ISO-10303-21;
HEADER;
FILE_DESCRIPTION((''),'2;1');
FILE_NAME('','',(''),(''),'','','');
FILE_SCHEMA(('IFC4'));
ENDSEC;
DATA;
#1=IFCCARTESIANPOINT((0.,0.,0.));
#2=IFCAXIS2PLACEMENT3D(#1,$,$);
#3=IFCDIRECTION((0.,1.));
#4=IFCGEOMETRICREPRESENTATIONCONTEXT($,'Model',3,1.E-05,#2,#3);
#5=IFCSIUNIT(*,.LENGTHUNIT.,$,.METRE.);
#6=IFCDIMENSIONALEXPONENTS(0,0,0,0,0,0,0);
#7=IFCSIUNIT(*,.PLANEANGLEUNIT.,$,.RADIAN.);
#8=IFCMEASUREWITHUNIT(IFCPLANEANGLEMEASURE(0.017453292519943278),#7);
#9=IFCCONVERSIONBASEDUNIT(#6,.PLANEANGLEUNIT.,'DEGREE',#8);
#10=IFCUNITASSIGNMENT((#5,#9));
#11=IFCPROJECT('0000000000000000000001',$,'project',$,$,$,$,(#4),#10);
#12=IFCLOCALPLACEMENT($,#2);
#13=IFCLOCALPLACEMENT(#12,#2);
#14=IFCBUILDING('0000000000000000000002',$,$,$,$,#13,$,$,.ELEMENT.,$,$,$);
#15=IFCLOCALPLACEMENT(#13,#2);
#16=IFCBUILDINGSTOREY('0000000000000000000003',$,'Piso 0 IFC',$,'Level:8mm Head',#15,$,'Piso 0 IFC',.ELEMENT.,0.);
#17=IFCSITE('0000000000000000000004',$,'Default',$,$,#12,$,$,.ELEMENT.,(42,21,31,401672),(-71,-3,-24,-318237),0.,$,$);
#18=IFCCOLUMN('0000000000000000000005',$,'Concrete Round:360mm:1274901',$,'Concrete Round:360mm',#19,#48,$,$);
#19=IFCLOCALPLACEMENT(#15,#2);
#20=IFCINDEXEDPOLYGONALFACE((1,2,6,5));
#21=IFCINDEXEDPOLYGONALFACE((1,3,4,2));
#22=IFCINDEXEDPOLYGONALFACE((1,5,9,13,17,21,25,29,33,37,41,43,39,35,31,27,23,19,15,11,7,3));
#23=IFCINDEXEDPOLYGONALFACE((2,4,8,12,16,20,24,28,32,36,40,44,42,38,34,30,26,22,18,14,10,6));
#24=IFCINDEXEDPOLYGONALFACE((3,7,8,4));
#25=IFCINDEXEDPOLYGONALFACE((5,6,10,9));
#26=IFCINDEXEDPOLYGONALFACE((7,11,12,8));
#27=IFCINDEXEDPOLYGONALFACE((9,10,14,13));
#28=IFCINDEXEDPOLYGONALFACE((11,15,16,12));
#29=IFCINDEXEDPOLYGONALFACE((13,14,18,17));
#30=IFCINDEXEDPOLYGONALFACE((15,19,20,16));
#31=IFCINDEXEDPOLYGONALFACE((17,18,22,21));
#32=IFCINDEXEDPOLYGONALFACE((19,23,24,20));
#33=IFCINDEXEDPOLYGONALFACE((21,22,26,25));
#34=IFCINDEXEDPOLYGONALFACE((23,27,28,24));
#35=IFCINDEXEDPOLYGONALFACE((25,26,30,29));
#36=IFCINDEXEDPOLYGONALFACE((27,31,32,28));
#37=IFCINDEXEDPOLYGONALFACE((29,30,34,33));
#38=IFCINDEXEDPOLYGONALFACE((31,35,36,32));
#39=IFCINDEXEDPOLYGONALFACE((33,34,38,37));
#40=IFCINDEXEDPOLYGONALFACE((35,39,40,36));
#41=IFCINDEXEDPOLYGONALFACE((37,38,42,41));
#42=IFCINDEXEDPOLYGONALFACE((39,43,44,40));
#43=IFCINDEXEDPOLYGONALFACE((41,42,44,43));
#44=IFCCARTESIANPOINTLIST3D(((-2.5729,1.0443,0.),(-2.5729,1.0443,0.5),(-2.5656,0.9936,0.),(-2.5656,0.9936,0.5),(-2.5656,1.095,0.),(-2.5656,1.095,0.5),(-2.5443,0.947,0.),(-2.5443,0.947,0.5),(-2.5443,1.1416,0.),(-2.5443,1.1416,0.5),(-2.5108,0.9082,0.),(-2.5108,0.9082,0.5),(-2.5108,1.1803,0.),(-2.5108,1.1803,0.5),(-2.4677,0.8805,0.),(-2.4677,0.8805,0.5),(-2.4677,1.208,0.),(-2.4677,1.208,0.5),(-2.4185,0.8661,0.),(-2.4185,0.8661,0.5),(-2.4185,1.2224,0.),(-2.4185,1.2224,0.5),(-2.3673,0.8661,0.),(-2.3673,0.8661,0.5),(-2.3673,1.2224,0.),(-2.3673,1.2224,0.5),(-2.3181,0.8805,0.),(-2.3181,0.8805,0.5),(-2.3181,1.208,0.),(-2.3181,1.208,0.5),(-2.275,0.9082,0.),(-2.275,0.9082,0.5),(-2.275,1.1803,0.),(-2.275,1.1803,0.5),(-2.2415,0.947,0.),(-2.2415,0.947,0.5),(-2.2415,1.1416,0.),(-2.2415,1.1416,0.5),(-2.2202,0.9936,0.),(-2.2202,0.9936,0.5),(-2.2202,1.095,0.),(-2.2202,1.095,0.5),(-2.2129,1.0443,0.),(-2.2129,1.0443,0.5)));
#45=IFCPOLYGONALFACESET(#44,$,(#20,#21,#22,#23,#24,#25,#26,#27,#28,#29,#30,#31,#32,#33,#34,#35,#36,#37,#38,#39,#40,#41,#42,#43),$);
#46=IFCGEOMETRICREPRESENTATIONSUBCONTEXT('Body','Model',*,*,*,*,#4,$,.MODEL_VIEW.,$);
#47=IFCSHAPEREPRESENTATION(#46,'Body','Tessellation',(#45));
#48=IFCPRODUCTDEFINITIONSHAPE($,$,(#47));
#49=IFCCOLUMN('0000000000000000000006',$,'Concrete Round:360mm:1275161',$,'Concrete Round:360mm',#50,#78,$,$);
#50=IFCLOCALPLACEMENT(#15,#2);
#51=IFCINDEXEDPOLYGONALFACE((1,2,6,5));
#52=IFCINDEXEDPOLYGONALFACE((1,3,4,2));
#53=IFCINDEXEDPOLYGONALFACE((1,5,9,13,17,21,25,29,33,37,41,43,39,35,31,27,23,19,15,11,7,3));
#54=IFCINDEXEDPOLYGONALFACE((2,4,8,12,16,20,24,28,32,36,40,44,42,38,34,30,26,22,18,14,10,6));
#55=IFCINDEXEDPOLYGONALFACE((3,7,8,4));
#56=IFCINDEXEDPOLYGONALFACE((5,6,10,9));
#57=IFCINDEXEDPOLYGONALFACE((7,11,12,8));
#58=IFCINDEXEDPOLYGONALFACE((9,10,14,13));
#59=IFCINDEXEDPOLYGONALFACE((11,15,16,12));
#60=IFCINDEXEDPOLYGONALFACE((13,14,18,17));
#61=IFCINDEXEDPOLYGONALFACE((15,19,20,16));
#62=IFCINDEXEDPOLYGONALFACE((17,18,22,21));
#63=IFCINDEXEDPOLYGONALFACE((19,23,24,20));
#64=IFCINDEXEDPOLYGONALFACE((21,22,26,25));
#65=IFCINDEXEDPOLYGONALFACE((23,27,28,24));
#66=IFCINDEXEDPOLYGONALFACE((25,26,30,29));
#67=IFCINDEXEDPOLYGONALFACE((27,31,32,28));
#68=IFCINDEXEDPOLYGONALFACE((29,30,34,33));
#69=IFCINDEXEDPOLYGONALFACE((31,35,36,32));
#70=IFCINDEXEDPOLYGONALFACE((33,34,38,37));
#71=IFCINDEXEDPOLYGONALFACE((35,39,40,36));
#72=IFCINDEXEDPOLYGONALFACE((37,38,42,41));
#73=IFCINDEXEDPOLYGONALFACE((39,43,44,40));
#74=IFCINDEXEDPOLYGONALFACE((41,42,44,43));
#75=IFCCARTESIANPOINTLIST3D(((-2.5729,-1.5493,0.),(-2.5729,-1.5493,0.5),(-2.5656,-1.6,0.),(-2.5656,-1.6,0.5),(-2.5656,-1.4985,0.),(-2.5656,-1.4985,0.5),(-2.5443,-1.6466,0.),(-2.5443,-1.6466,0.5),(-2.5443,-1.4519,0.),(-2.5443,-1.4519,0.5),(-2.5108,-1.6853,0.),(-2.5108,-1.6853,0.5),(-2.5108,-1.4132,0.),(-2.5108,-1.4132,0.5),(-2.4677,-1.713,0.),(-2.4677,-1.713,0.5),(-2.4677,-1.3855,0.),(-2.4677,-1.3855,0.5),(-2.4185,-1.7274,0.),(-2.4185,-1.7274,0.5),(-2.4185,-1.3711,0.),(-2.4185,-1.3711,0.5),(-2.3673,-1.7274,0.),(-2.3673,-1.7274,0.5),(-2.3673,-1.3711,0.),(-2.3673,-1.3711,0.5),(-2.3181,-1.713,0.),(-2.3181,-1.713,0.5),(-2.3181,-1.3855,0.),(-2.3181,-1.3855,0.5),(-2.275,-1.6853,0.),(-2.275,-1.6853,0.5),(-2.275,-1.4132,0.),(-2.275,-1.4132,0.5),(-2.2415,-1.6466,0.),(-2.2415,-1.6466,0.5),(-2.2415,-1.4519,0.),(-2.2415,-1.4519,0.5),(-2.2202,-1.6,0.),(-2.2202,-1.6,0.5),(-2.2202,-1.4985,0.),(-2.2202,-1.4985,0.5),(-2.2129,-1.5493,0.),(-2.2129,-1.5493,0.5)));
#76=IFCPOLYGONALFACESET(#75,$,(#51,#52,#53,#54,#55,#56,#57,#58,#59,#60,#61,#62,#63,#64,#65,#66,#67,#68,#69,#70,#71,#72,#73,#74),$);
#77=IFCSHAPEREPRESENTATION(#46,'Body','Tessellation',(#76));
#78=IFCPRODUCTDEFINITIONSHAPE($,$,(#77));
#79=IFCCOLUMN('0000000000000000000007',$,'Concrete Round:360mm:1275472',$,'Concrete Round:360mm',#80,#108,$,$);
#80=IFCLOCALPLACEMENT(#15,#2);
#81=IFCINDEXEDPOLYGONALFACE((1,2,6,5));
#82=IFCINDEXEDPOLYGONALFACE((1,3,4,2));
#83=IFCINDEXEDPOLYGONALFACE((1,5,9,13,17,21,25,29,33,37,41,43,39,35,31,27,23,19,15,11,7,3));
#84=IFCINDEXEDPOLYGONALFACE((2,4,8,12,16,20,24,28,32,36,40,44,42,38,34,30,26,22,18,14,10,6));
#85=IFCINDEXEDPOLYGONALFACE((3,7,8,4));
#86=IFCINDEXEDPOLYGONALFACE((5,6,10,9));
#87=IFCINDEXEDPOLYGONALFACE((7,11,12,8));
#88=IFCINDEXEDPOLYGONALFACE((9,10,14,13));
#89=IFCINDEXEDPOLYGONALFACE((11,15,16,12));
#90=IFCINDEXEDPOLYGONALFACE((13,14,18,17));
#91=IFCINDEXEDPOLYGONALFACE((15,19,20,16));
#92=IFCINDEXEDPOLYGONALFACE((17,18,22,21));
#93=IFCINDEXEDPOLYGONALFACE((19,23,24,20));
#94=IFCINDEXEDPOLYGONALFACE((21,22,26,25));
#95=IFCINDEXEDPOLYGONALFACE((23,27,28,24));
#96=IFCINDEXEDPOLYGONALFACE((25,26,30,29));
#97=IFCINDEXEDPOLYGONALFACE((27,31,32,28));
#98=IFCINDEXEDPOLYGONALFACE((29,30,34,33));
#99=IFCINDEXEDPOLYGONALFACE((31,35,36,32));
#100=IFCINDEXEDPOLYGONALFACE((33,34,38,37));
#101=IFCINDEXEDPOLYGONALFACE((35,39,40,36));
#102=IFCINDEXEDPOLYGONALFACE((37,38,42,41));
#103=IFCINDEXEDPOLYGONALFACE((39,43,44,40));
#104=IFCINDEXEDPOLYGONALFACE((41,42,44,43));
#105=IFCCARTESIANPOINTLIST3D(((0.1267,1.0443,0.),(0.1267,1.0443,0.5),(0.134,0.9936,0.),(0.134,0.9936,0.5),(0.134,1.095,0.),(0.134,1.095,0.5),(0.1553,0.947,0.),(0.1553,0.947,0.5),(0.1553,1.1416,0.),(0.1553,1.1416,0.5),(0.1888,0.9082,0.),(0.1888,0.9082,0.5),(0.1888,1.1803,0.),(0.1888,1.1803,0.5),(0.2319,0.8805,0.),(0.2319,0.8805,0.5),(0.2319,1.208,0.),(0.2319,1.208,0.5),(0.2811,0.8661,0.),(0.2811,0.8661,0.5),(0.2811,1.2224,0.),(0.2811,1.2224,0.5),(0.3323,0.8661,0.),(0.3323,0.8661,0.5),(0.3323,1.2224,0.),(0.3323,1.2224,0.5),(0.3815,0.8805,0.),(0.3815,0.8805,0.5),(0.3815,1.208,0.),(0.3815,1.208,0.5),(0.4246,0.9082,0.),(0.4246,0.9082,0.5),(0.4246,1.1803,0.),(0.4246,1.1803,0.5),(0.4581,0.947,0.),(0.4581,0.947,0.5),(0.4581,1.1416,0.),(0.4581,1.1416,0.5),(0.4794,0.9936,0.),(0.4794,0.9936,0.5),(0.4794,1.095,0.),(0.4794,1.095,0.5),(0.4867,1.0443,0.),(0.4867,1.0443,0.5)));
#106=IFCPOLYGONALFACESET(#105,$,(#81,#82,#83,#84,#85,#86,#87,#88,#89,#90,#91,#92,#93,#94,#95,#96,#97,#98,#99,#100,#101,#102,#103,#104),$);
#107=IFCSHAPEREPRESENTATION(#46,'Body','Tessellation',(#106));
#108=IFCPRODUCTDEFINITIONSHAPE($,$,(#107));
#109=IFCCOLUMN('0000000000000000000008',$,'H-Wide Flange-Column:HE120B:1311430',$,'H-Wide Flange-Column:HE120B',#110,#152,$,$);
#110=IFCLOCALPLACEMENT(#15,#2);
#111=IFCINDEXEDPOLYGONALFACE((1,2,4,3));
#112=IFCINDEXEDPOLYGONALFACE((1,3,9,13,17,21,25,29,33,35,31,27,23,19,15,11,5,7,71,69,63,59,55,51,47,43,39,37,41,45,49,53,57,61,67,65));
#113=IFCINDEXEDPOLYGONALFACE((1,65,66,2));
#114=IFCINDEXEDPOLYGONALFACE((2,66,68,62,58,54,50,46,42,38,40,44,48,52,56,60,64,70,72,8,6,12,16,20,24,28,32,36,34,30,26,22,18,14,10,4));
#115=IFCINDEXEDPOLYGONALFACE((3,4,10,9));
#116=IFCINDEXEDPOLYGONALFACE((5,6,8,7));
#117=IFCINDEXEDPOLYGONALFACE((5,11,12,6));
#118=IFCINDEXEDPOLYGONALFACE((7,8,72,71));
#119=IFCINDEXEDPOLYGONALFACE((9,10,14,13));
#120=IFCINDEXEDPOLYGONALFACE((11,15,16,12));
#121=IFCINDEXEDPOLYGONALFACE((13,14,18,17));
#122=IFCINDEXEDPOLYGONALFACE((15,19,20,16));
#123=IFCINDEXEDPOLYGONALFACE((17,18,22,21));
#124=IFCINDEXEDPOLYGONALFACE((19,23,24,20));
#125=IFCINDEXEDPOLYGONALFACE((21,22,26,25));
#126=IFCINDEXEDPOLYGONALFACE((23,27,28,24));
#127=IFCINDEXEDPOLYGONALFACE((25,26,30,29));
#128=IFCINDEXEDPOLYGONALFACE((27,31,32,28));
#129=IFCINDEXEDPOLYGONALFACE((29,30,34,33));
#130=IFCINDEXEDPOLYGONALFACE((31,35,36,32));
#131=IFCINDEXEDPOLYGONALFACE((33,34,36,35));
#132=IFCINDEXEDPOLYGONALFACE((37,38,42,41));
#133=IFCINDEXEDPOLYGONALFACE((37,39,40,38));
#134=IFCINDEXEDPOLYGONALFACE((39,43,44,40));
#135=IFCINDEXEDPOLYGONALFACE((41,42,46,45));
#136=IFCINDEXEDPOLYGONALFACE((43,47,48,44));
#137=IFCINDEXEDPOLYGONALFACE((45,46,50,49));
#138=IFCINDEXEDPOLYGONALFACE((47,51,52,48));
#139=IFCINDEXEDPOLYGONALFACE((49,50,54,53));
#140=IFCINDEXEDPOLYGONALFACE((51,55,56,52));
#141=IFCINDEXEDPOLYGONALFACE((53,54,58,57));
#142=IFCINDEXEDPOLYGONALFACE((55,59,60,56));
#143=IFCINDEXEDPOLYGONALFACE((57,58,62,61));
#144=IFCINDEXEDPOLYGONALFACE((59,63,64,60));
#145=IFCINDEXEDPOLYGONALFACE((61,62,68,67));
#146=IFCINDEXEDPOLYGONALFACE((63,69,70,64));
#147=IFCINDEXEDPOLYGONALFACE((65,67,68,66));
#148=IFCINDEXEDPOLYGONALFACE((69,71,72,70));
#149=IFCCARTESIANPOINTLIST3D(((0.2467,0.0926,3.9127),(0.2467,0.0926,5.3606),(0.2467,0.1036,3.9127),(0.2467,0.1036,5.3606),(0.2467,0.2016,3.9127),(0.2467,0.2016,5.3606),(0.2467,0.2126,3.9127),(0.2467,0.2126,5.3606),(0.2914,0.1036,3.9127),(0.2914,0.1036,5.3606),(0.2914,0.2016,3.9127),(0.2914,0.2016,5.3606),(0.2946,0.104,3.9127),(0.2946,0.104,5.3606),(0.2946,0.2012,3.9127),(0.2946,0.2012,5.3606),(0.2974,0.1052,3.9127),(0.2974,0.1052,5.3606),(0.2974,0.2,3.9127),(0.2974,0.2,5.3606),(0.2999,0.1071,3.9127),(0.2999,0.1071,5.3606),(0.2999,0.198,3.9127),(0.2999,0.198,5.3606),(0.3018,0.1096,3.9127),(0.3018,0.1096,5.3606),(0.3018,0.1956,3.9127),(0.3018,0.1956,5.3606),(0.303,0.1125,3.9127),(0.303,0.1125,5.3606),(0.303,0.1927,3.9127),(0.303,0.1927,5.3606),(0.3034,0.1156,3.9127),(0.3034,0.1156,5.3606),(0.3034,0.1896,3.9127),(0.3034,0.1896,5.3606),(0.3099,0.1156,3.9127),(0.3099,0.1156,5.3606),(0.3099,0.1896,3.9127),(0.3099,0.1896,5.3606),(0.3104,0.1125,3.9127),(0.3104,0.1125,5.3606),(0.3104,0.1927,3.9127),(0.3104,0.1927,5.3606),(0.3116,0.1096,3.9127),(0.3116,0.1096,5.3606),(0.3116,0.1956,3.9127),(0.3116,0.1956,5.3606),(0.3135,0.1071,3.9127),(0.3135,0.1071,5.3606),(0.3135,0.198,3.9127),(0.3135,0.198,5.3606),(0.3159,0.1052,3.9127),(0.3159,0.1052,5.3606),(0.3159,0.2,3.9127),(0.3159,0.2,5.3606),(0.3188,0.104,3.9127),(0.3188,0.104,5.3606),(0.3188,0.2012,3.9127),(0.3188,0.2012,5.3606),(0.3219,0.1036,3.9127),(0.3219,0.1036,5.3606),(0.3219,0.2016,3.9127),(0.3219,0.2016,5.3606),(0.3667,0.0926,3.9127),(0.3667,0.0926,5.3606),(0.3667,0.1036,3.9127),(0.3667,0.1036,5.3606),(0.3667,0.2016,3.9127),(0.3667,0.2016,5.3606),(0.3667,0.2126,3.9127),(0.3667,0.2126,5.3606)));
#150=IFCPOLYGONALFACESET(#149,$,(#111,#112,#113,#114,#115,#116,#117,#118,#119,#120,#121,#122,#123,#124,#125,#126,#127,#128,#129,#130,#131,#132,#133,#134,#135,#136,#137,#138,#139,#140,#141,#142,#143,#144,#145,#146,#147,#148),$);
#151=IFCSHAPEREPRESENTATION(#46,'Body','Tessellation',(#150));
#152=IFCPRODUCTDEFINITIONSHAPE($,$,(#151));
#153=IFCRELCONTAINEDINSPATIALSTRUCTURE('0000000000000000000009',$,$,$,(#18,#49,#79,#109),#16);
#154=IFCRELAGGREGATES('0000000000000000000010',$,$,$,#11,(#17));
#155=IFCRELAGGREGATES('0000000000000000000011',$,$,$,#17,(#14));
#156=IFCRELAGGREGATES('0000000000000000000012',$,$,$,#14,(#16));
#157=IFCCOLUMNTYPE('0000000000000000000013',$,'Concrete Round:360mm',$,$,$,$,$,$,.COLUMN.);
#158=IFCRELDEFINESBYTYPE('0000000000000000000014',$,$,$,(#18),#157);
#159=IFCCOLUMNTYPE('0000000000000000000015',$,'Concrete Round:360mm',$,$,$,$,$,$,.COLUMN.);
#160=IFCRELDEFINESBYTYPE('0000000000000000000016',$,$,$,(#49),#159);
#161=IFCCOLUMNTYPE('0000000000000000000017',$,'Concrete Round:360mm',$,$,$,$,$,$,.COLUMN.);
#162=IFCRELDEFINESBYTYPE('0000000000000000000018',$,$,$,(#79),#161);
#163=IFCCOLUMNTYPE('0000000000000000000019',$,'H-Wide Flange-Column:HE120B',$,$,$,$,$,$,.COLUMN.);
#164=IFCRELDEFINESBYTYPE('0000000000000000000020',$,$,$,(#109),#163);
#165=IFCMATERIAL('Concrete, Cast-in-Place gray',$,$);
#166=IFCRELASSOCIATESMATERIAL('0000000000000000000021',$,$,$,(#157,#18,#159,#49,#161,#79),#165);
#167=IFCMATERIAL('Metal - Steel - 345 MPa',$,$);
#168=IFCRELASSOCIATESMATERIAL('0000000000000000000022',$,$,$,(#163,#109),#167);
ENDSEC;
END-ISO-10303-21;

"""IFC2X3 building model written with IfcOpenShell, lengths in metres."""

from ifc_helpers import new_model, entity, si_unit, converted_unit, direction, frame, frame_2d, origin, place, context, subcontext, project, spatial, circle, i_section, extrude, source, transform, mapped, material, type_object, type_shapes, element, save


model = new_model("IFC2X3")

# Units and contexts
model_context = context("Model", 3, precision=1e-05, world=origin(), true_north=direction((0.0, 1.0)))
body_context = subcontext(model_context, "Body", "Model", "MODEL_VIEW")
ifc_project = project(units=[si_unit("LENGTHUNIT", "METRE"), converted_unit("PLANEANGLEUNIT", "DEGREE", entity("IfcPlaneAngleMeasure", 0.017453292519943278), si_unit("PLANEANGLEUNIT", "RADIAN"), dimensions=[0, 0, 0, 0, 0, 0, 0])], contexts=[model_context])

# Site, building, storey
site_placement = place(None, origin())
site = spatial("IfcSite", under=ifc_project, at=site_placement, Name="Default", CompositionType="ELEMENT", RefLatitude=(42, 21, 31, 401672), RefLongitude=(-71, -3, -24, -318237), RefElevation=0.0)
building_placement = place(site_placement, origin())
building = spatial("IfcBuilding", under=site, at=building_placement, CompositionType="ELEMENT")
storey_placement = place(building_placement, origin())
storey = spatial("IfcBuildingStorey", under=building, at=storey_placement, Name="Piso 0 IFC", ObjectType="Level:8mm Head", LongName="Piso 0 IFC", CompositionType="ELEMENT", Elevation=0.0)

# Columns
ifc_material_1 = material(Name="Metal - Steel - 345 MPa")
ifc_material_2 = material(Name="Concrete, Cast-in-Place gray")
column_type_1 = type_object("IfcColumnType", Name="Concrete Round:360mm", PredefinedType="COLUMN", material=ifc_material_2)
shared_shape_1 = source(origin(), body_context, "Body", "SweptSolid", [
    extrude(circle(Radius=0.18, at=frame_2d((0.0, 0.0), x_axis=(1.0, 0.0))), frame((-2.3929, 1.0443, 0.0)), (0.0, 0.0, 1.0), 0.5),
])
type_shapes(column_type_1, [shared_shape_1])
column_1_placement = place(storey_placement, origin())
element("IfcColumn", 1, at=column_1_placement, inside=storey, type_object=column_type_1, material=ifc_material_2, Name="Concrete Round:360mm:1274901", ObjectType="Concrete Round:360mm", context=body_context, shape_type="MappedRepresentation", body=[
    mapped(shared_shape_1, transform((0.0, 0.0, 0.0), scale=1.0)),
])
column_type_2 = type_object("IfcColumnType", Name="Concrete Round:360mm", PredefinedType="COLUMN", material=ifc_material_2)
shared_shape_2 = source(origin(), body_context, "Body", "SweptSolid", [
    extrude(circle(Radius=0.18, at=frame_2d((0.0, 0.0), x_axis=(1.0, 0.0))), frame((-2.3929, -1.5493, 0.0)), (0.0, 0.0, 1.0), 0.5),
])
type_shapes(column_type_2, [shared_shape_2])
column_2_placement = place(storey_placement, origin())
element("IfcColumn", 2, at=column_2_placement, inside=storey, type_object=column_type_2, material=ifc_material_2, Name="Concrete Round:360mm:1275161", ObjectType="Concrete Round:360mm", context=body_context, shape_type="MappedRepresentation", body=[
    mapped(shared_shape_2, transform((0.0, 0.0, 0.0), scale=1.0)),
])
column_type_3 = type_object("IfcColumnType", Name="Concrete Round:360mm", PredefinedType="COLUMN", material=ifc_material_2)
shared_shape_3 = source(origin(), body_context, "Body", "SweptSolid", [
    extrude(circle(Radius=0.18, at=frame_2d((0.0, 0.0), x_axis=(1.0, 0.0))), frame((0.3067, 1.0443, 0.0)), (0.0, 0.0, 1.0), 0.5),
])
type_shapes(column_type_3, [shared_shape_3])
column_3_placement = place(storey_placement, origin())
element("IfcColumn", 3, at=column_3_placement, inside=storey, type_object=column_type_3, material=ifc_material_2, Name="Concrete Round:360mm:1275472", ObjectType="Concrete Round:360mm", context=body_context, shape_type="MappedRepresentation", body=[
    mapped(shared_shape_3, transform((0.0, 0.0, 0.0), scale=1.0)),
])
column_type_4 = type_object("IfcColumnType", Name="H-Wide Flange-Column:HE120B", PredefinedType="COLUMN", material=ifc_material_1)
shared_shape_4 = source(origin(), body_context, "Body", "SweptSolid", [
    extrude(i_section(OverallWidth=0.12, OverallDepth=0.12, WebThickness=0.0065, FlangeThickness=0.011, FilletRadius=0.012, at=frame_2d((0.0, 0.0), x_axis=(0.0, 1.0))), frame((0.3067, 0.1526, 3.9127), z_axis=(0.0, 0.0, 1.0), x_axis=(0.0, -1.0, 0.0)), (0.0, 0.0, 1.0), 1.4479),
])
type_shapes(column_type_4, [shared_shape_4])
column_4_placement = place(storey_placement, origin())
element("IfcColumn", 4, at=column_4_placement, inside=storey, type_object=column_type_4, material=ifc_material_1, Name="H-Wide Flange-Column:HE120B:1311430", ObjectType="H-Wide Flange-Column:HE120B", context=body_context, shape_type="MappedRepresentation", body=[
    mapped(shared_shape_4, transform((0.0, 0.0, 0.0), scale=1.0)),
])

save(model, "model.ifc")
